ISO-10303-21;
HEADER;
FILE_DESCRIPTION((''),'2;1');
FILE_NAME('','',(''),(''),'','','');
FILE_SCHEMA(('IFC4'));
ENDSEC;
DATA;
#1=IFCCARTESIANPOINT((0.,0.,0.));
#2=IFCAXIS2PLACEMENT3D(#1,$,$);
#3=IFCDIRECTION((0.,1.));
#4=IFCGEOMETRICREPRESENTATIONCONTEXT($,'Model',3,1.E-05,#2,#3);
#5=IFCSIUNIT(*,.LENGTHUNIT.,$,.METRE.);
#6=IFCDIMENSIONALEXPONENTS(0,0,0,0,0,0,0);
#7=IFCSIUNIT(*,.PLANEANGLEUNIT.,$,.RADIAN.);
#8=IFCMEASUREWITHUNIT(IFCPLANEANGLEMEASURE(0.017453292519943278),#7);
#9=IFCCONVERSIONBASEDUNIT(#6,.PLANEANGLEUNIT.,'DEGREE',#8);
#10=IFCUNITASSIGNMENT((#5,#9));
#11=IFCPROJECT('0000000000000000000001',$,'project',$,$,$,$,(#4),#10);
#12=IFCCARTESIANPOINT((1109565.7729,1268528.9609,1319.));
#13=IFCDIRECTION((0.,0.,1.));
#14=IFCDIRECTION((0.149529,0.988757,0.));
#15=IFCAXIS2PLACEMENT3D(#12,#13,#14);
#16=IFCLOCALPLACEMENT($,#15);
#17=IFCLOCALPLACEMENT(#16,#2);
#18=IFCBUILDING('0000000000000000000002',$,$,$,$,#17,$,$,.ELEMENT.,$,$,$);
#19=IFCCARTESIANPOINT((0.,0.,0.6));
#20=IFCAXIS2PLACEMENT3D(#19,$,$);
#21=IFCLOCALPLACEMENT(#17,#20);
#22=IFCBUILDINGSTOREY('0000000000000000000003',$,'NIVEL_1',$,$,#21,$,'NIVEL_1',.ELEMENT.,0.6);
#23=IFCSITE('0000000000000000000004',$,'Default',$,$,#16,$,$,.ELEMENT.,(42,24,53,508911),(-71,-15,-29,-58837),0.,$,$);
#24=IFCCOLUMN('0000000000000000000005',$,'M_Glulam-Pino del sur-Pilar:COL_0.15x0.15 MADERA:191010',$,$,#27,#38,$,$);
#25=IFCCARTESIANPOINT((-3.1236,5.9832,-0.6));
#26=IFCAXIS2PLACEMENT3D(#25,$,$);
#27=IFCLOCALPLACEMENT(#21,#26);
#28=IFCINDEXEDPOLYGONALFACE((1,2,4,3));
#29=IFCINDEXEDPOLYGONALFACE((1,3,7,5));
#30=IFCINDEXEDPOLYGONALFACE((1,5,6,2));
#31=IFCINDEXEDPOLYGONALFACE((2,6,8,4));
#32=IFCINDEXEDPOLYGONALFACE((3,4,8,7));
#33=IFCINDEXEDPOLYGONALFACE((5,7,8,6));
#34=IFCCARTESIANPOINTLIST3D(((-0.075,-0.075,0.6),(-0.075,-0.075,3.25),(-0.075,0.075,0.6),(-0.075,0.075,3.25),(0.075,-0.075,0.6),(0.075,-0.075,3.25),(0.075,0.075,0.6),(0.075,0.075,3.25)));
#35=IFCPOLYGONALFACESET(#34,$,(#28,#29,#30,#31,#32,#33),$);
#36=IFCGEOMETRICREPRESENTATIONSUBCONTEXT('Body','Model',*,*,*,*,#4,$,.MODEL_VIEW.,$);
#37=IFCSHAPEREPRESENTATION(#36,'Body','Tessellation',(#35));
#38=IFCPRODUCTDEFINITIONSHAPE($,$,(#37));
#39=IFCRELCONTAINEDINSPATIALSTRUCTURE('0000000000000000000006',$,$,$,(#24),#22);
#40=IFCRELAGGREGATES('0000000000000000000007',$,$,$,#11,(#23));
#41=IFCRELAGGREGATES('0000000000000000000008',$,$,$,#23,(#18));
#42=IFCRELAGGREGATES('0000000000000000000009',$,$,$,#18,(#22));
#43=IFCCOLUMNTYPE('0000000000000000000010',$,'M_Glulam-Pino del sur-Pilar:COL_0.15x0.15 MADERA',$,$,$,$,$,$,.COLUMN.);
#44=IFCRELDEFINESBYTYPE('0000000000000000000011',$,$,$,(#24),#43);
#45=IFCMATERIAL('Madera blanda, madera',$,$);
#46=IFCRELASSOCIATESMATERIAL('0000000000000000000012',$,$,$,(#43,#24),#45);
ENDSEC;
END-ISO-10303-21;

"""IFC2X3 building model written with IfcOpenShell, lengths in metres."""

from ifc_helpers import new_model, entity, si_unit, converted_unit, direction, frame, origin, origin_2d_with_axis, place, context, subcontext, project, spatial, rectangle, extrude, source, transform, mapped, material, type_object, type_shapes, element, save


model = new_model("IFC2X3")

# Units and contexts
model_context = context("Model", 3, precision=1e-05, world=origin(), true_north=direction((0.0, 1.0)))
body_context = subcontext(model_context, "Body", "Model", "MODEL_VIEW")
ifc_project = project(units=[si_unit("LENGTHUNIT", "METRE"), converted_unit("PLANEANGLEUNIT", "DEGREE", entity("IfcPlaneAngleMeasure", 0.017453292519943278), si_unit("PLANEANGLEUNIT", "RADIAN"), dimensions=[0, 0, 0, 0, 0, 0, 0])], contexts=[model_context])

# Site, building, storey
site_placement = place(None, frame((1109565.7729, 1268528.9609, 1319.0), z_axis=(0.0, 0.0, 1.0), x_axis=(0.149529, 0.988757, 0.0)))
site = spatial("IfcSite", under=ifc_project, at=site_placement, Name="Default", CompositionType="ELEMENT", RefLatitude=(42, 24, 53, 508911), RefLongitude=(-71, -15, -29, -58837), RefElevation=0.0)
building_placement = place(site_placement, origin())
building = spatial("IfcBuilding", under=site, at=building_placement, CompositionType="ELEMENT")
storey_placement = place(building_placement, frame((0.0, 0.0, 0.6)))
storey = spatial("IfcBuildingStorey", under=building, at=storey_placement, Name="NIVEL_1", LongName="NIVEL_1", CompositionType="ELEMENT", Elevation=0.6)

# Column
ifc_material_1 = material(Name="Madera blanda, madera")
column_type = type_object("IfcColumnType", Name="M_Glulam-Pino del sur-Pilar:COL_0.15x0.15 MADERA", PredefinedType="COLUMN", material=ifc_material_1)
shared_shape_1 = source(origin(), body_context, "Body", "SweptSolid", [
    extrude(rectangle(XDim=0.15, YDim=0.15, at=origin_2d_with_axis()), frame((0.0, 0.0, 0.6), z_axis=(0.0, 0.0, 1.0), x_axis=(-1.0, 0.0, 0.0)), (0.0, 0.0, 1.0), 2.65),
])
type_shapes(column_type, [shared_shape_1])
column_placement = place(storey_placement, frame((-3.1236, 5.9832, -0.6)))
element("IfcColumn", 1, at=column_placement, inside=storey, type_object=column_type, material=ifc_material_1, Name="M_Glulam-Pino del sur-Pilar:COL_0.15x0.15 MADERA:191010", context=body_context, shape_type="MappedRepresentation", body=[
    mapped(shared_shape_1, transform((0.0, 0.0, 0.0), scale=1.0)),
])

save(model, "model.ifc")
